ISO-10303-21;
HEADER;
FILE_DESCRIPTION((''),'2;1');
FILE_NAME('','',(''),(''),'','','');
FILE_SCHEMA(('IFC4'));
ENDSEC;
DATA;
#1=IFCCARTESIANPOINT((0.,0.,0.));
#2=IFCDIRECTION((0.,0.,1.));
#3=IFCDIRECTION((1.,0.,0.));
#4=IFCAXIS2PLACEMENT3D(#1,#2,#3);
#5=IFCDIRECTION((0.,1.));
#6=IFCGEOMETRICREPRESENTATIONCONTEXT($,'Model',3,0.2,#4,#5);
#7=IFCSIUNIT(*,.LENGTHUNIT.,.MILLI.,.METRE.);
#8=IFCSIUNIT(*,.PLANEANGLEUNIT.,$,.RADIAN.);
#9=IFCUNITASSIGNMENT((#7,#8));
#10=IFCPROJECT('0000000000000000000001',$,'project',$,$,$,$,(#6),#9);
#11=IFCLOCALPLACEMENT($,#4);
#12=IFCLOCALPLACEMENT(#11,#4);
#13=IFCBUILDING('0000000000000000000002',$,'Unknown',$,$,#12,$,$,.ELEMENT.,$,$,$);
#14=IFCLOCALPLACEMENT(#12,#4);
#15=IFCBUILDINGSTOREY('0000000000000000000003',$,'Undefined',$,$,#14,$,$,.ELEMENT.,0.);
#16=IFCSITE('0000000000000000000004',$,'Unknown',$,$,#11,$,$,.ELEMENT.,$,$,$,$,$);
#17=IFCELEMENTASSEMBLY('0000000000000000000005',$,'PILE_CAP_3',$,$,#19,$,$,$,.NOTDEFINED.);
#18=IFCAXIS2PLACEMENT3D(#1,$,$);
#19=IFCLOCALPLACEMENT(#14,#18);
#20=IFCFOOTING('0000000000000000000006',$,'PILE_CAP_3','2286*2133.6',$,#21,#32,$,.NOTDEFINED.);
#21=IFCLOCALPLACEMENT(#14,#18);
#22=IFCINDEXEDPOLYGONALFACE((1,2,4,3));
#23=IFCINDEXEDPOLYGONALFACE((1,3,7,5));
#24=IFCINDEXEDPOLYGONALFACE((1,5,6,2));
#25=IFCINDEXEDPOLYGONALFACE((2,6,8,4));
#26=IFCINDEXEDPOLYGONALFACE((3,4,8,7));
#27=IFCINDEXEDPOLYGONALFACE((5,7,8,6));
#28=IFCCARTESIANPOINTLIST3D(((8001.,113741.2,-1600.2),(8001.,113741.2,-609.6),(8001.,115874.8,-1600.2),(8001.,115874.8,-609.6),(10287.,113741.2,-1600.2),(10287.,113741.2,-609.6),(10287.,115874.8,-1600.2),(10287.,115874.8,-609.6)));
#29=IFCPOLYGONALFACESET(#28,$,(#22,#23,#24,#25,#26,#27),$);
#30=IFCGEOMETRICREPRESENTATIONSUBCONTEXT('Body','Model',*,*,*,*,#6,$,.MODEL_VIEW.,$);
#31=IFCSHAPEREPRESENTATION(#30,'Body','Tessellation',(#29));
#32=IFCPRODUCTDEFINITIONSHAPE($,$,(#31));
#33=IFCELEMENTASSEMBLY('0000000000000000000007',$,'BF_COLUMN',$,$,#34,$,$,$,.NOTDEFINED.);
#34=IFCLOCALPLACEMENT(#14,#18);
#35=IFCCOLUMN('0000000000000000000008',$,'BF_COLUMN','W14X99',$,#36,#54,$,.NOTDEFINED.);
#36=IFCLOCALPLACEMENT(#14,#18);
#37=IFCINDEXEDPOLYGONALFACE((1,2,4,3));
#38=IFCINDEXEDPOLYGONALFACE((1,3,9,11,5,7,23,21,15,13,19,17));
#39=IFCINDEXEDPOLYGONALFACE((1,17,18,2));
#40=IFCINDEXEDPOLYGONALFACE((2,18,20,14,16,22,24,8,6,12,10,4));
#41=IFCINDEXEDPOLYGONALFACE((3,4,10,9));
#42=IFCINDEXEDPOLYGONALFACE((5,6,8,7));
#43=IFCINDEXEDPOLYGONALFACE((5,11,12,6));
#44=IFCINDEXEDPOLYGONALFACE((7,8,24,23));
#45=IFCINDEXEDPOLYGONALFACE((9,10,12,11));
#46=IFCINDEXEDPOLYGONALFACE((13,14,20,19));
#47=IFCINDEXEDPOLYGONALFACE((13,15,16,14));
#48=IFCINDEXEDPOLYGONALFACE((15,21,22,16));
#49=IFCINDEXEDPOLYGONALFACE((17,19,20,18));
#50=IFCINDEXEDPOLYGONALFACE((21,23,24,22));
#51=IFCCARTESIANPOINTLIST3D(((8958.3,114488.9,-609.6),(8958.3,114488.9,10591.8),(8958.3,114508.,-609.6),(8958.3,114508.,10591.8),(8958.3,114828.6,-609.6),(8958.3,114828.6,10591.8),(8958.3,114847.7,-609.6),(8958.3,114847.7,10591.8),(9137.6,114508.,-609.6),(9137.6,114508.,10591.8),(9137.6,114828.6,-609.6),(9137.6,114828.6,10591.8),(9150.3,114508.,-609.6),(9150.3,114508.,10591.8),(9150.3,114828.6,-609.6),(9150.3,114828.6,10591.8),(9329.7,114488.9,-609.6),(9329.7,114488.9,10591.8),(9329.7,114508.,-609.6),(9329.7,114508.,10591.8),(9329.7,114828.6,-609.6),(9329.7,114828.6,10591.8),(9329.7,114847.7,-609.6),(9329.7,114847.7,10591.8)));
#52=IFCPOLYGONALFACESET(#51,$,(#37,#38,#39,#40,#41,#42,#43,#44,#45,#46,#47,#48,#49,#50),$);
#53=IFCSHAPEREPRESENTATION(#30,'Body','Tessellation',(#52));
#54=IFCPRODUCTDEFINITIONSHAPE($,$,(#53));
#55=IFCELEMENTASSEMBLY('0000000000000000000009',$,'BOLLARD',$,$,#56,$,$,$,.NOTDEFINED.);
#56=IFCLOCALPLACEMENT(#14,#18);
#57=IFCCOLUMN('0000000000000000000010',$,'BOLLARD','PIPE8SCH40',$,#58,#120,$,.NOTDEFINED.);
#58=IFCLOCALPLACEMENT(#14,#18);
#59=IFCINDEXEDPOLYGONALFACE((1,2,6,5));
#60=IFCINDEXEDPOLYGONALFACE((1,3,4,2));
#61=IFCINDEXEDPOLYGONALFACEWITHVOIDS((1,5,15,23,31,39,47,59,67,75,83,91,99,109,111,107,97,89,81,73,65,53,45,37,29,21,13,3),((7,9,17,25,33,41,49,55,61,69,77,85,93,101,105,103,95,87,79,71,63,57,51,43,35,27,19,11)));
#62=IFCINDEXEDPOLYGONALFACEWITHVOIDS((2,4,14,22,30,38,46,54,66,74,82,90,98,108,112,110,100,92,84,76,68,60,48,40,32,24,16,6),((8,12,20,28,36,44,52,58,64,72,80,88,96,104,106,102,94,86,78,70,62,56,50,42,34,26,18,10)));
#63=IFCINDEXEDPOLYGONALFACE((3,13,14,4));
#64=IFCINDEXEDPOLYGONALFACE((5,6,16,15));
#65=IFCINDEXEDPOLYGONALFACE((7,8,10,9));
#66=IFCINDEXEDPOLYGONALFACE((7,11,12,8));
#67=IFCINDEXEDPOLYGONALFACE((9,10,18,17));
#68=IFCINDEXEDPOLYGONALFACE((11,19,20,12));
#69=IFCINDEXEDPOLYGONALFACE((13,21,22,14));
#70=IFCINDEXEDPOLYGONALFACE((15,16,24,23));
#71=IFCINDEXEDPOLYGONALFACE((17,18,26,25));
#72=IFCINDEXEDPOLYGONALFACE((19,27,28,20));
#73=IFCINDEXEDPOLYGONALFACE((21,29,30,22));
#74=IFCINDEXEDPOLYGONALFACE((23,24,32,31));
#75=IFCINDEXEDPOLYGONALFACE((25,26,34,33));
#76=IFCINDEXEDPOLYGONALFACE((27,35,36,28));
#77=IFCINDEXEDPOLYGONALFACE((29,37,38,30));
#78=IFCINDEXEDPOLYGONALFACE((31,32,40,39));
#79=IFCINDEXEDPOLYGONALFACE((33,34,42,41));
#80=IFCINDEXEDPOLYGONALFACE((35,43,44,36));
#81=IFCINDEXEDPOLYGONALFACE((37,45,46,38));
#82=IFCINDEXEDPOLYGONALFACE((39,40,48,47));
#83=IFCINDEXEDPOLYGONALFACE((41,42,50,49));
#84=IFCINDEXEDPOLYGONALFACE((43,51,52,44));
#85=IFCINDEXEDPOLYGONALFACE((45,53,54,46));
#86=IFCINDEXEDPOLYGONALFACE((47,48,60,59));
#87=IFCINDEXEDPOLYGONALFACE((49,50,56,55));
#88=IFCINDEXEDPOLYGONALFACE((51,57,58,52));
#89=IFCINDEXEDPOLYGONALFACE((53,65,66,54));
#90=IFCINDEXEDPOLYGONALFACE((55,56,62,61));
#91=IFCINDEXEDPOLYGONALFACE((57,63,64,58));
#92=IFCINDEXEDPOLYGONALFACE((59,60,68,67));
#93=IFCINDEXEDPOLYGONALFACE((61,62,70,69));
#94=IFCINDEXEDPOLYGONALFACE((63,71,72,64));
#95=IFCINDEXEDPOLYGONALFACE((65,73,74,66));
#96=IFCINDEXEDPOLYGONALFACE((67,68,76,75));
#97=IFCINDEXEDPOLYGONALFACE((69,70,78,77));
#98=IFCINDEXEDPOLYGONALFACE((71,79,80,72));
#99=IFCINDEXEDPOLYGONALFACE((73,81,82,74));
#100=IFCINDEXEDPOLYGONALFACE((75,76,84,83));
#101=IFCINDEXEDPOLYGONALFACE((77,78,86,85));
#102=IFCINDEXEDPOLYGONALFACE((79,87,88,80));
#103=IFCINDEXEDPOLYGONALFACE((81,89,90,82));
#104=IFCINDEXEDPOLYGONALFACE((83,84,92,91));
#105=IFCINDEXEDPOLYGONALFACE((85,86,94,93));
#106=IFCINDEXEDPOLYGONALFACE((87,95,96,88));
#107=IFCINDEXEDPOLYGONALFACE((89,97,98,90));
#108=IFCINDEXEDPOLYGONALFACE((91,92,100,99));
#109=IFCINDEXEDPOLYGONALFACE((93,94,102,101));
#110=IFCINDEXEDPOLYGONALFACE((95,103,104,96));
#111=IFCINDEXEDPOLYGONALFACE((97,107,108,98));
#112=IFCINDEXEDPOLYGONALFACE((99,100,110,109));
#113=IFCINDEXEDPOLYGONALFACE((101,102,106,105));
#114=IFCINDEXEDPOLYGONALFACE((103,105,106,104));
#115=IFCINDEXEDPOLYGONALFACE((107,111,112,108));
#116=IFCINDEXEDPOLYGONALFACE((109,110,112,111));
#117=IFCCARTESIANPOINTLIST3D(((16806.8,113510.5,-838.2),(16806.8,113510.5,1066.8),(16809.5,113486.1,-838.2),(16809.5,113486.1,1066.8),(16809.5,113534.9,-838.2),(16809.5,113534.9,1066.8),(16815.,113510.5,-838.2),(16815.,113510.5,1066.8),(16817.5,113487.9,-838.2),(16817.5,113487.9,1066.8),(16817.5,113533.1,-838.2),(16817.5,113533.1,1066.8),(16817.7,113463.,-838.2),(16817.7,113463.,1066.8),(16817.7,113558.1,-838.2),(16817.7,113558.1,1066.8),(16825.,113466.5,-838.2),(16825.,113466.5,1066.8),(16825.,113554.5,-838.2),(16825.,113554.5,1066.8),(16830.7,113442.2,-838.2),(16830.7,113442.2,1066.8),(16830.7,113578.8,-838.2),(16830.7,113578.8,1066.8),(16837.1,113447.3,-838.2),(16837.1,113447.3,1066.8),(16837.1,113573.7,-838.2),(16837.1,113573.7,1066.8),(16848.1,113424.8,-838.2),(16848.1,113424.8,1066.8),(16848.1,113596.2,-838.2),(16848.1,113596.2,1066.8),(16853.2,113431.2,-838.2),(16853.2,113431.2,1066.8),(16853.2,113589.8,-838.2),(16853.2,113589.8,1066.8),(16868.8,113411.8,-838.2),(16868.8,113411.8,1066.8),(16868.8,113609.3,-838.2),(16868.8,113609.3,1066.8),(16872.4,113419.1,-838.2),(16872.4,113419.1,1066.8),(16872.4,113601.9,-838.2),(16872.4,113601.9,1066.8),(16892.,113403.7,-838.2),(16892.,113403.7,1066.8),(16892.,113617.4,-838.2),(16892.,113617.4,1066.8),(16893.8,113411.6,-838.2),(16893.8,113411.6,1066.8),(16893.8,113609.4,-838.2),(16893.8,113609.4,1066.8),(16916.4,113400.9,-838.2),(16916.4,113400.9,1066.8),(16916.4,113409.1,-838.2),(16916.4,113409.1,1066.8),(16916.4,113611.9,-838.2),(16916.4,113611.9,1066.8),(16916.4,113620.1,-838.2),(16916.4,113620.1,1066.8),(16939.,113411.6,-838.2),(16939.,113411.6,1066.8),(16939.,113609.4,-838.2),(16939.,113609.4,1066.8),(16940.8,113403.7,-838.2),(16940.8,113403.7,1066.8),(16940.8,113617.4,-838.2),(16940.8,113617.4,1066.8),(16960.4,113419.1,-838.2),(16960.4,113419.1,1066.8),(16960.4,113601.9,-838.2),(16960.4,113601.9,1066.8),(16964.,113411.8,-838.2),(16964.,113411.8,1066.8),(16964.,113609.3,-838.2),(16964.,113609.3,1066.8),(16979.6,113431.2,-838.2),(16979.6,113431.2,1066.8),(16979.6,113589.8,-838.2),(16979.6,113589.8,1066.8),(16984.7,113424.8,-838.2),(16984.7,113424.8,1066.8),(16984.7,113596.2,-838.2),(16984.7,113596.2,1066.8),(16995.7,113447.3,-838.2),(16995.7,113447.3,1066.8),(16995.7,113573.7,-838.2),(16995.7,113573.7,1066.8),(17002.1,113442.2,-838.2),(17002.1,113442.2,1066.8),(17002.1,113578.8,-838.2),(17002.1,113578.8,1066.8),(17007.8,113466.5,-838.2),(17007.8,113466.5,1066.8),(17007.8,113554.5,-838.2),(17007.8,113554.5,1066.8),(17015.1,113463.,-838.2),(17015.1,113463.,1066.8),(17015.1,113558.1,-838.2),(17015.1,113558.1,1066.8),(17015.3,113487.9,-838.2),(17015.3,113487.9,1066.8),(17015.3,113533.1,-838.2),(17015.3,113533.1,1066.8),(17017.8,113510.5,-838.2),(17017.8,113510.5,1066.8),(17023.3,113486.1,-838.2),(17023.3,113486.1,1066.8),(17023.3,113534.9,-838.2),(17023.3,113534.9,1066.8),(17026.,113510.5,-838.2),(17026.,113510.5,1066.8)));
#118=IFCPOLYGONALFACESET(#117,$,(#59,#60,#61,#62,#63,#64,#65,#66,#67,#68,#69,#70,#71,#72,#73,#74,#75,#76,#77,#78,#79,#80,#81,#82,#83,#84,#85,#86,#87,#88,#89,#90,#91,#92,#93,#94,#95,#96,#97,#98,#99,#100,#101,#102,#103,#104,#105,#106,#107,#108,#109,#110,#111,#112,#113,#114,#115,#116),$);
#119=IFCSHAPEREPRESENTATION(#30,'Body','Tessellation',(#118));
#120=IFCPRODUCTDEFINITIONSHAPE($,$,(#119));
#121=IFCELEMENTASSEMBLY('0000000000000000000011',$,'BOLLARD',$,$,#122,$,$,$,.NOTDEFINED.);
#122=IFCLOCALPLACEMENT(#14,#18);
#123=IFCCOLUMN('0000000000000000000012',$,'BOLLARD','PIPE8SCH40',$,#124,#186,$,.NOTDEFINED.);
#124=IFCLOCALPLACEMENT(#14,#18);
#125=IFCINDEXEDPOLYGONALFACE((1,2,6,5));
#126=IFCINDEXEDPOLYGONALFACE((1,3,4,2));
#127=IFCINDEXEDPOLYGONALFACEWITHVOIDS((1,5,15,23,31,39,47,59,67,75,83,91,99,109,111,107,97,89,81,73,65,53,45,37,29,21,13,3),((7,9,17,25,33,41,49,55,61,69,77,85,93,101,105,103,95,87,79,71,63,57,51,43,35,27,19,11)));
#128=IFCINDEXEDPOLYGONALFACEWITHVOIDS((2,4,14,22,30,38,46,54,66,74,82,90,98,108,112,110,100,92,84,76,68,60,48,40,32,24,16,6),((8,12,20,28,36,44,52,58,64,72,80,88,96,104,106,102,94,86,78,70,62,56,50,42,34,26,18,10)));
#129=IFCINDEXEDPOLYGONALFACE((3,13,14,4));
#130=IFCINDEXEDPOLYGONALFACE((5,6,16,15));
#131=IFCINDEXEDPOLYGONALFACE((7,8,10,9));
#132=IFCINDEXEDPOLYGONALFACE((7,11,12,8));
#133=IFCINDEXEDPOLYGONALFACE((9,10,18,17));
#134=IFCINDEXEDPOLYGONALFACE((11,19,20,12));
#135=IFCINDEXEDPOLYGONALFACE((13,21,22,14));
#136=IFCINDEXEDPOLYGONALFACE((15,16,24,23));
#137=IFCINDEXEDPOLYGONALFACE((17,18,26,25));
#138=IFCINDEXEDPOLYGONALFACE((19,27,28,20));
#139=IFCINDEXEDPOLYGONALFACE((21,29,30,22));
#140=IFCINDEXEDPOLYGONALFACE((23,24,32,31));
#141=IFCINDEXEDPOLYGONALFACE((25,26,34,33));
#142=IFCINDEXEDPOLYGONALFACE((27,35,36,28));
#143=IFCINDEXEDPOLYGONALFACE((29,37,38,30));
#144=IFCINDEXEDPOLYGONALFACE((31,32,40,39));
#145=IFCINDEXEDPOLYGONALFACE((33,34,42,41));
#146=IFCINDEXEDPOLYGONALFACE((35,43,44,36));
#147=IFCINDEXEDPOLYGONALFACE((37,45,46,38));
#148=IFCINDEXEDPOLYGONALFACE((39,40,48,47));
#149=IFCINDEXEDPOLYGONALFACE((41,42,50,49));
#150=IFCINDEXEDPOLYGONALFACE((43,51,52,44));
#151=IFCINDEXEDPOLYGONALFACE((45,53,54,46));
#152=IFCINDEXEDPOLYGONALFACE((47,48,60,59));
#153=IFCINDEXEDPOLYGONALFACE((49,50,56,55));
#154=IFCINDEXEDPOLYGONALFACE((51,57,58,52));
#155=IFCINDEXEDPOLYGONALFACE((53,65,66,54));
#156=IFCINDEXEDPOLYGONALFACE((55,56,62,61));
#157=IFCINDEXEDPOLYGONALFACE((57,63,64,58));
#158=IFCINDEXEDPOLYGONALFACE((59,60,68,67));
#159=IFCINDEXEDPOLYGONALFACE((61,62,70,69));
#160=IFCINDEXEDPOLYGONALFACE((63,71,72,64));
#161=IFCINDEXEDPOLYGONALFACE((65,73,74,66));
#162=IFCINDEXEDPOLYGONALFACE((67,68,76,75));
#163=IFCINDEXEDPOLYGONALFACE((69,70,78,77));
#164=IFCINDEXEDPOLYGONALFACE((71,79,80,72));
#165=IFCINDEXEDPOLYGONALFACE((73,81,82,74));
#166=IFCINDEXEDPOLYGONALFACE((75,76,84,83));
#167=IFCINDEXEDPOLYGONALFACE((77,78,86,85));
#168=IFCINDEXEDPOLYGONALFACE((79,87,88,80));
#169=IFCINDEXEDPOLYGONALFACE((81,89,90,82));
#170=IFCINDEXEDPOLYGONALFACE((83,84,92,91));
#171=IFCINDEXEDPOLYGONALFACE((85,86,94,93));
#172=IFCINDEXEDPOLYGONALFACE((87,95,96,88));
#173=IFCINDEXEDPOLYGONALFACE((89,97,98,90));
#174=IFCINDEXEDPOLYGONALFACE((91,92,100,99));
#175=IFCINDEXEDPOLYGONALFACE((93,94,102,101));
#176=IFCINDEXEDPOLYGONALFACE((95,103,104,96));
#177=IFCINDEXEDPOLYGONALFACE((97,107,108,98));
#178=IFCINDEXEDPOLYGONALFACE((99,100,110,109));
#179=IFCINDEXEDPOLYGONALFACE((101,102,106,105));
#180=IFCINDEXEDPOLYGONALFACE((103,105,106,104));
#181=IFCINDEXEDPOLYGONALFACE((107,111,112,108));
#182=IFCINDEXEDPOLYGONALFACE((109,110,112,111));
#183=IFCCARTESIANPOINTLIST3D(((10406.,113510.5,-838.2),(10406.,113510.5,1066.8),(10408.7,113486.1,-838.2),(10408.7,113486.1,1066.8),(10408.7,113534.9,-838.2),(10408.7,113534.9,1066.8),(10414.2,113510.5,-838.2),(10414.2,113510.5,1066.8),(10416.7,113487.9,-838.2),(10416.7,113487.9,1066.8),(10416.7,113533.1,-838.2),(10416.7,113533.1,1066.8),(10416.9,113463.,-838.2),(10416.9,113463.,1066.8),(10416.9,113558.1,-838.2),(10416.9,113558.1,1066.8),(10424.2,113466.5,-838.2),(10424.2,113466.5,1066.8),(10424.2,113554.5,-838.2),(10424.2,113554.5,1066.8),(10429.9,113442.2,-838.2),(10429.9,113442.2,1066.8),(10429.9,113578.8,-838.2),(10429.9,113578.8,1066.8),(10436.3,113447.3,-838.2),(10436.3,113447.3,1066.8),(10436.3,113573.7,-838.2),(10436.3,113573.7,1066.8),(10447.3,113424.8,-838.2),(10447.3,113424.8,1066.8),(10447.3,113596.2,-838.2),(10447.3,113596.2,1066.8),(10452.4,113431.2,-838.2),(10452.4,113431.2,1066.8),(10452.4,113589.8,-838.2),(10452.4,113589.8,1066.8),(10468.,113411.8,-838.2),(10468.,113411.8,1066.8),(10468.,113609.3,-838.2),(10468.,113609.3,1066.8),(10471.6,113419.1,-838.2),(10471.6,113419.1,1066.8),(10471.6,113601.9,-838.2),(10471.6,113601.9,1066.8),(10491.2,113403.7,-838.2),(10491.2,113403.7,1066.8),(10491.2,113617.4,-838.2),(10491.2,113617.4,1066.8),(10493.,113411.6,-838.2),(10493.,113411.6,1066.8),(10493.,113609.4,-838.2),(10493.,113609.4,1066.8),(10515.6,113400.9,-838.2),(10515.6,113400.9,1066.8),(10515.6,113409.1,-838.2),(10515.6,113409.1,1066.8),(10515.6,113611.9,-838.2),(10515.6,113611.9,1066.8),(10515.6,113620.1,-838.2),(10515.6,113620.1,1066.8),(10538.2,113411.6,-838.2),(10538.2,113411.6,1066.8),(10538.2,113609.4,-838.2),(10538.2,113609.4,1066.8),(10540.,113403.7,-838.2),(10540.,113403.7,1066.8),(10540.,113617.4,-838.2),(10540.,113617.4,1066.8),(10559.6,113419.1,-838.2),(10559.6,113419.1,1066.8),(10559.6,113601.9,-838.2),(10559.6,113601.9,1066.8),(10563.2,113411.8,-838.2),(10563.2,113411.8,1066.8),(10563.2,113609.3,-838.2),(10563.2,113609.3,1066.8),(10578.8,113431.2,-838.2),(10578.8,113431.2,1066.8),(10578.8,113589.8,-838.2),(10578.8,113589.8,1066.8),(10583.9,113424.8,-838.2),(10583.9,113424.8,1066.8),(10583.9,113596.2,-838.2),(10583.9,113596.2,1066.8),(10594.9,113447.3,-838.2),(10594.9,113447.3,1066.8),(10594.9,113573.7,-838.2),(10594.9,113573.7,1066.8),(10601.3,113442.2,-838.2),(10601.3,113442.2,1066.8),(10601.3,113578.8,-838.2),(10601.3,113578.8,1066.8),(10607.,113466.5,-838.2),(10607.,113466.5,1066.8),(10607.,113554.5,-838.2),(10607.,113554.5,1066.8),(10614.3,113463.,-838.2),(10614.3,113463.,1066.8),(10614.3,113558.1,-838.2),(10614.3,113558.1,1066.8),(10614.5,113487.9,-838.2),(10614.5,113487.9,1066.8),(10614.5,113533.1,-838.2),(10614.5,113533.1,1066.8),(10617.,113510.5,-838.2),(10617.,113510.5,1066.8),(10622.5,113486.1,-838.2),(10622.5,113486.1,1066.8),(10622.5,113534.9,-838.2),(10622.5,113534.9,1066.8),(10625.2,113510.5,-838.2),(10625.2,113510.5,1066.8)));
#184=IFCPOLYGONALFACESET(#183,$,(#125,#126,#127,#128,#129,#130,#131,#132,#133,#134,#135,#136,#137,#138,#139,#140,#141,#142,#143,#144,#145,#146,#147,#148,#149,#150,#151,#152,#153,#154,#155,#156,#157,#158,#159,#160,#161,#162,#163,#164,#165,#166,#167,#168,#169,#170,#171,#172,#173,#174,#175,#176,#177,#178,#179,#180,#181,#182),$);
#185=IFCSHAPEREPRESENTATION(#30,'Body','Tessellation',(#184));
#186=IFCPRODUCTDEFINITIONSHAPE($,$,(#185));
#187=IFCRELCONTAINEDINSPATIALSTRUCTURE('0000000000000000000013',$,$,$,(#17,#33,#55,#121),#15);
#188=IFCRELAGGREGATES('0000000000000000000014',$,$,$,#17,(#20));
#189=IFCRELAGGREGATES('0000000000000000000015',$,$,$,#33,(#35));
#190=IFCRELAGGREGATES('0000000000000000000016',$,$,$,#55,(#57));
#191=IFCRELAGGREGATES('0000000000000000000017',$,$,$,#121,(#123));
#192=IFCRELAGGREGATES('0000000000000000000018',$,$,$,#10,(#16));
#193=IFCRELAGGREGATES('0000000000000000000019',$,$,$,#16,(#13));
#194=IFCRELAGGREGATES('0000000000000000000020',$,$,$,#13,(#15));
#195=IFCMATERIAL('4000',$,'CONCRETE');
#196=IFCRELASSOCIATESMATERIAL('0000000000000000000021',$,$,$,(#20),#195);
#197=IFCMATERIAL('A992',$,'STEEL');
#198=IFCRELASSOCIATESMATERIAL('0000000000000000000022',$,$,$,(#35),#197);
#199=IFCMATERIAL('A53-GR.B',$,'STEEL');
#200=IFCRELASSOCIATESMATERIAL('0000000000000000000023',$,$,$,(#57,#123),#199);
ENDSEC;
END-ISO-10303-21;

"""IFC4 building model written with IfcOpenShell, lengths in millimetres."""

from ifc_helpers import new_model, si_unit, direction, frame, origin_with_axes, place, context, subcontext, project, spatial, line, indexed_curve, outline, extrude, material, element, aggregate, save


model = new_model("IFC4")

# Units and contexts
model_context = context("Model", 3, precision=0.2, world=origin_with_axes(), true_north=direction((0.0, 1.0)))
body_context = subcontext(model_context, "Body", "Model", "MODEL_VIEW")
ifc_project = project(units=[si_unit("LENGTHUNIT", "METRE", prefix="MILLI"), si_unit("PLANEANGLEUNIT", "RADIAN")], contexts=[model_context])

# Site, building, storey
site_placement = place(None, origin_with_axes())
site = spatial("IfcSite", under=ifc_project, at=site_placement, Name="Unknown", CompositionType="ELEMENT")
building_placement = place(site_placement, origin_with_axes())
building = spatial("IfcBuilding", under=site, at=building_placement, Name="Unknown", CompositionType="ELEMENT")
storey_placement = place(building_placement, origin_with_axes())
storey = spatial("IfcBuildingStorey", under=building, at=storey_placement, Name="Undefined", CompositionType="ELEMENT", Elevation=0.0)

# Element assembly, footing
assembly_1_placement = place(storey_placement, frame((9144.0, 114808.0, -1600.2), z_axis=(0.0, 1.0, 0.0), x_axis=(0.0, 0.0, 1.0)))
assembly_1 = element("IfcElementAssembly", 1, at=assembly_1_placement, inside=storey, Name="PILE_CAP_3", PredefinedType="NOTDEFINED")
ifc_material_1 = material(Name="4000", Category="CONCRETE")
footing_placement = place(assembly_1_placement, origin_with_axes())
footing = element("IfcFooting", 2, at=footing_placement, material=ifc_material_1, Name="PILE_CAP_3", Description="2286*2133.6", PredefinedType="NOTDEFINED", context=body_context, shape_type="SolidModel", body=[
    extrude(outline(indexed_curve([(-1066.8, -1143.0), (1066.8, -1143.0), (1066.8, 1143.0), (-1066.8, 1143.0)], segments=[line(1, 2, 3, 4, 1)])), frame((0.0, 0.0, 0.0), z_axis=(-1.0, 0.0, 0.0), x_axis=(0.0, 0.0, 1.0)), (0.0, 0.0, -1.0), 990.6),
])
aggregate(assembly_1, [footing])

# Element assemblies, columns
assembly_2_placement = place(storey_placement, frame((9144.0, 114668.3, -609.6), z_axis=(-1.0, 0.0, 0.0), x_axis=(0.0, 0.0, 1.0)))
assembly_2 = element("IfcElementAssembly", 3, at=assembly_2_placement, inside=storey, Name="BF_COLUMN", PredefinedType="NOTDEFINED")
ifc_material_2 = material(Name="A992", Category="STEEL")
column_1_placement = place(assembly_2_placement, origin_with_axes())
column_1 = element("IfcColumn", 4, at=column_1_placement, material=ifc_material_2, Name="BF_COLUMN", Description="W14X99", PredefinedType="NOTDEFINED", context=body_context, shape_type="SolidModel", body=[
    extrude(outline(indexed_curve([(-185.7, -179.4), (185.7, -179.4), (185.7, -160.3), (6.3, -160.3), (6.3, 160.3), (185.7, 160.3), (185.7, 179.4), (-185.7, 179.4), (-185.7, 160.3), (-6.3, 160.3), (-6.3, -160.3), (-185.7, -160.3)], segments=[line(1, 2, 3, 4, 5, 6, 7, 8, 9, 10, 11, 12, 1)])), frame((0.0, 0.0, 0.0), z_axis=(-1.0, 0.0, 0.0), x_axis=(0.0, 0.0, 1.0)), (0.0, 0.0, -1.0), 11201.4),
])
aggregate(assembly_2, [column_1])
assembly_3_placement = place(storey_placement, frame((16916.4, 113510.5, -838.2), z_axis=(-1.0, 0.0, 0.0), x_axis=(0.0, 0.0, 1.0)))
assembly_3 = element("IfcElementAssembly", 5, at=assembly_3_placement, inside=storey, Name="BOLLARD", PredefinedType="NOTDEFINED")
ifc_material_3 = material(Name="A53-GR.B", Category="STEEL")
column_2_placement = place(assembly_3_placement, origin_with_axes())
column_2 = element("IfcColumn", 6, at=column_2_placement, material=ifc_material_3, Name="BOLLARD", Description="PIPE8SCH40", PredefinedType="NOTDEFINED", context=body_context, shape_type="SolidModel", body=[
    extrude(outline(indexed_curve([(109.6, 0.0), (106.9, 24.4), (98.7, 47.6), (85.7, 68.3), (68.3, 85.7), (47.6, 98.7), (24.4, 106.9), (0.0, 109.6), (-24.4, 106.9), (-47.6, 98.7), (-68.3, 85.7), (-85.7, 68.3), (-98.7, 47.6), (-106.9, 24.4), (-109.6, 0.0), (-106.9, -24.4), (-98.7, -47.6), (-85.7, -68.3), (-68.3, -85.7), (-47.6, -98.7), (-24.4, -106.9), (0.0, -109.6), (24.4, -106.9), (47.6, -98.7), (68.3, -85.7), (85.7, -68.3), (98.7, -47.6), (106.9, -24.4)], segments=[line(1, 2, 3, 4, 5, 6, 7, 8, 9, 10, 11, 12, 13, 14, 15, 16, 17, 18, 19, 20, 21, 22, 23, 24, 25, 26, 27, 28, 1)]), holes=[indexed_curve([(101.4, 0.0), (98.9, -22.6), (91.4, -44.0), (79.3, -63.2), (63.2, -79.3), (44.0, -91.4), (22.6, -98.9), (0.0, -101.4), (-22.6, -98.9), (-44.0, -91.4), (-63.2, -79.3), (-79.3, -63.2), (-91.4, -44.0), (-98.9, -22.6), (-101.4, 0.0), (-98.9, 22.6), (-91.4, 44.0), (-79.3, 63.2), (-63.2, 79.3), (-44.0, 91.4), (-22.6, 98.9), (0.0, 101.4), (22.6, 98.9), (44.0, 91.4), (63.2, 79.3), (79.3, 63.2), (91.4, 44.0), (98.9, 22.6)], segments=[line(1, 2, 3, 4, 5, 6, 7, 8, 9, 10, 11, 12, 13, 14, 15, 16, 17, 18, 19, 20, 21, 22, 23, 24, 25, 26, 27, 28, 1)])]), frame((0.0, 0.0, 0.0), z_axis=(-1.0, 0.0, 0.0), x_axis=(0.0, 0.0, 1.0)), (0.0, 0.0, -1.0), 1905.0),
])
aggregate(assembly_3, [column_2])
assembly_4_placement = place(storey_placement, frame((10515.6, 113510.5, -838.2), z_axis=(-1.0, 0.0, 0.0), x_axis=(0.0, 0.0, 1.0)))
assembly_4 = element("IfcElementAssembly", 7, at=assembly_4_placement, inside=storey, Name="BOLLARD", PredefinedType="NOTDEFINED")
column_3_placement = place(assembly_4_placement, origin_with_axes())
column_3 = element("IfcColumn", 8, at=column_3_placement, material=ifc_material_3, Name="BOLLARD", Description="PIPE8SCH40", PredefinedType="NOTDEFINED", context=body_context, shape_type="SolidModel", body=[
    extrude(outline(indexed_curve([(109.6, 0.0), (106.9, 24.4), (98.7, 47.6), (85.7, 68.3), (68.3, 85.7), (47.6, 98.7), (24.4, 106.9), (0.0, 109.6), (-24.4, 106.9), (-47.6, 98.7), (-68.3, 85.7), (-85.7, 68.3), (-98.7, 47.6), (-106.9, 24.4), (-109.6, 0.0), (-106.9, -24.4), (-98.7, -47.6), (-85.7, -68.3), (-68.3, -85.7), (-47.6, -98.7), (-24.4, -106.9), (0.0, -109.6), (24.4, -106.9), (47.6, -98.7), (68.3, -85.7), (85.7, -68.3), (98.7, -47.6), (106.9, -24.4)], segments=[line(1, 2, 3, 4, 5, 6, 7, 8, 9, 10, 11, 12, 13, 14, 15, 16, 17, 18, 19, 20, 21, 22, 23, 24, 25, 26, 27, 28, 1)]), holes=[indexed_curve([(101.4, 0.0), (98.9, -22.6), (91.4, -44.0), (79.3, -63.2), (63.2, -79.3), (44.0, -91.4), (22.6, -98.9), (0.0, -101.4), (-22.6, -98.9), (-44.0, -91.4), (-63.2, -79.3), (-79.3, -63.2), (-91.4, -44.0), (-98.9, -22.6), (-101.4, 0.0), (-98.9, 22.6), (-91.4, 44.0), (-79.3, 63.2), (-63.2, 79.3), (-44.0, 91.4), (-22.6, 98.9), (0.0, 101.4), (22.6, 98.9), (44.0, 91.4), (63.2, 79.3), (79.3, 63.2), (91.4, 44.0), (98.9, 22.6)], segments=[line(1, 2, 3, 4, 5, 6, 7, 8, 9, 10, 11, 12, 13, 14, 15, 16, 17, 18, 19, 20, 21, 22, 23, 24, 25, 26, 27, 28, 1)])]), frame((0.0, 0.0, 0.0), z_axis=(-1.0, 0.0, 0.0), x_axis=(0.0, 0.0, 1.0)), (0.0, 0.0, -1.0), 1905.0),
])
aggregate(assembly_4, [column_3])

save(model, "model.ifc")
